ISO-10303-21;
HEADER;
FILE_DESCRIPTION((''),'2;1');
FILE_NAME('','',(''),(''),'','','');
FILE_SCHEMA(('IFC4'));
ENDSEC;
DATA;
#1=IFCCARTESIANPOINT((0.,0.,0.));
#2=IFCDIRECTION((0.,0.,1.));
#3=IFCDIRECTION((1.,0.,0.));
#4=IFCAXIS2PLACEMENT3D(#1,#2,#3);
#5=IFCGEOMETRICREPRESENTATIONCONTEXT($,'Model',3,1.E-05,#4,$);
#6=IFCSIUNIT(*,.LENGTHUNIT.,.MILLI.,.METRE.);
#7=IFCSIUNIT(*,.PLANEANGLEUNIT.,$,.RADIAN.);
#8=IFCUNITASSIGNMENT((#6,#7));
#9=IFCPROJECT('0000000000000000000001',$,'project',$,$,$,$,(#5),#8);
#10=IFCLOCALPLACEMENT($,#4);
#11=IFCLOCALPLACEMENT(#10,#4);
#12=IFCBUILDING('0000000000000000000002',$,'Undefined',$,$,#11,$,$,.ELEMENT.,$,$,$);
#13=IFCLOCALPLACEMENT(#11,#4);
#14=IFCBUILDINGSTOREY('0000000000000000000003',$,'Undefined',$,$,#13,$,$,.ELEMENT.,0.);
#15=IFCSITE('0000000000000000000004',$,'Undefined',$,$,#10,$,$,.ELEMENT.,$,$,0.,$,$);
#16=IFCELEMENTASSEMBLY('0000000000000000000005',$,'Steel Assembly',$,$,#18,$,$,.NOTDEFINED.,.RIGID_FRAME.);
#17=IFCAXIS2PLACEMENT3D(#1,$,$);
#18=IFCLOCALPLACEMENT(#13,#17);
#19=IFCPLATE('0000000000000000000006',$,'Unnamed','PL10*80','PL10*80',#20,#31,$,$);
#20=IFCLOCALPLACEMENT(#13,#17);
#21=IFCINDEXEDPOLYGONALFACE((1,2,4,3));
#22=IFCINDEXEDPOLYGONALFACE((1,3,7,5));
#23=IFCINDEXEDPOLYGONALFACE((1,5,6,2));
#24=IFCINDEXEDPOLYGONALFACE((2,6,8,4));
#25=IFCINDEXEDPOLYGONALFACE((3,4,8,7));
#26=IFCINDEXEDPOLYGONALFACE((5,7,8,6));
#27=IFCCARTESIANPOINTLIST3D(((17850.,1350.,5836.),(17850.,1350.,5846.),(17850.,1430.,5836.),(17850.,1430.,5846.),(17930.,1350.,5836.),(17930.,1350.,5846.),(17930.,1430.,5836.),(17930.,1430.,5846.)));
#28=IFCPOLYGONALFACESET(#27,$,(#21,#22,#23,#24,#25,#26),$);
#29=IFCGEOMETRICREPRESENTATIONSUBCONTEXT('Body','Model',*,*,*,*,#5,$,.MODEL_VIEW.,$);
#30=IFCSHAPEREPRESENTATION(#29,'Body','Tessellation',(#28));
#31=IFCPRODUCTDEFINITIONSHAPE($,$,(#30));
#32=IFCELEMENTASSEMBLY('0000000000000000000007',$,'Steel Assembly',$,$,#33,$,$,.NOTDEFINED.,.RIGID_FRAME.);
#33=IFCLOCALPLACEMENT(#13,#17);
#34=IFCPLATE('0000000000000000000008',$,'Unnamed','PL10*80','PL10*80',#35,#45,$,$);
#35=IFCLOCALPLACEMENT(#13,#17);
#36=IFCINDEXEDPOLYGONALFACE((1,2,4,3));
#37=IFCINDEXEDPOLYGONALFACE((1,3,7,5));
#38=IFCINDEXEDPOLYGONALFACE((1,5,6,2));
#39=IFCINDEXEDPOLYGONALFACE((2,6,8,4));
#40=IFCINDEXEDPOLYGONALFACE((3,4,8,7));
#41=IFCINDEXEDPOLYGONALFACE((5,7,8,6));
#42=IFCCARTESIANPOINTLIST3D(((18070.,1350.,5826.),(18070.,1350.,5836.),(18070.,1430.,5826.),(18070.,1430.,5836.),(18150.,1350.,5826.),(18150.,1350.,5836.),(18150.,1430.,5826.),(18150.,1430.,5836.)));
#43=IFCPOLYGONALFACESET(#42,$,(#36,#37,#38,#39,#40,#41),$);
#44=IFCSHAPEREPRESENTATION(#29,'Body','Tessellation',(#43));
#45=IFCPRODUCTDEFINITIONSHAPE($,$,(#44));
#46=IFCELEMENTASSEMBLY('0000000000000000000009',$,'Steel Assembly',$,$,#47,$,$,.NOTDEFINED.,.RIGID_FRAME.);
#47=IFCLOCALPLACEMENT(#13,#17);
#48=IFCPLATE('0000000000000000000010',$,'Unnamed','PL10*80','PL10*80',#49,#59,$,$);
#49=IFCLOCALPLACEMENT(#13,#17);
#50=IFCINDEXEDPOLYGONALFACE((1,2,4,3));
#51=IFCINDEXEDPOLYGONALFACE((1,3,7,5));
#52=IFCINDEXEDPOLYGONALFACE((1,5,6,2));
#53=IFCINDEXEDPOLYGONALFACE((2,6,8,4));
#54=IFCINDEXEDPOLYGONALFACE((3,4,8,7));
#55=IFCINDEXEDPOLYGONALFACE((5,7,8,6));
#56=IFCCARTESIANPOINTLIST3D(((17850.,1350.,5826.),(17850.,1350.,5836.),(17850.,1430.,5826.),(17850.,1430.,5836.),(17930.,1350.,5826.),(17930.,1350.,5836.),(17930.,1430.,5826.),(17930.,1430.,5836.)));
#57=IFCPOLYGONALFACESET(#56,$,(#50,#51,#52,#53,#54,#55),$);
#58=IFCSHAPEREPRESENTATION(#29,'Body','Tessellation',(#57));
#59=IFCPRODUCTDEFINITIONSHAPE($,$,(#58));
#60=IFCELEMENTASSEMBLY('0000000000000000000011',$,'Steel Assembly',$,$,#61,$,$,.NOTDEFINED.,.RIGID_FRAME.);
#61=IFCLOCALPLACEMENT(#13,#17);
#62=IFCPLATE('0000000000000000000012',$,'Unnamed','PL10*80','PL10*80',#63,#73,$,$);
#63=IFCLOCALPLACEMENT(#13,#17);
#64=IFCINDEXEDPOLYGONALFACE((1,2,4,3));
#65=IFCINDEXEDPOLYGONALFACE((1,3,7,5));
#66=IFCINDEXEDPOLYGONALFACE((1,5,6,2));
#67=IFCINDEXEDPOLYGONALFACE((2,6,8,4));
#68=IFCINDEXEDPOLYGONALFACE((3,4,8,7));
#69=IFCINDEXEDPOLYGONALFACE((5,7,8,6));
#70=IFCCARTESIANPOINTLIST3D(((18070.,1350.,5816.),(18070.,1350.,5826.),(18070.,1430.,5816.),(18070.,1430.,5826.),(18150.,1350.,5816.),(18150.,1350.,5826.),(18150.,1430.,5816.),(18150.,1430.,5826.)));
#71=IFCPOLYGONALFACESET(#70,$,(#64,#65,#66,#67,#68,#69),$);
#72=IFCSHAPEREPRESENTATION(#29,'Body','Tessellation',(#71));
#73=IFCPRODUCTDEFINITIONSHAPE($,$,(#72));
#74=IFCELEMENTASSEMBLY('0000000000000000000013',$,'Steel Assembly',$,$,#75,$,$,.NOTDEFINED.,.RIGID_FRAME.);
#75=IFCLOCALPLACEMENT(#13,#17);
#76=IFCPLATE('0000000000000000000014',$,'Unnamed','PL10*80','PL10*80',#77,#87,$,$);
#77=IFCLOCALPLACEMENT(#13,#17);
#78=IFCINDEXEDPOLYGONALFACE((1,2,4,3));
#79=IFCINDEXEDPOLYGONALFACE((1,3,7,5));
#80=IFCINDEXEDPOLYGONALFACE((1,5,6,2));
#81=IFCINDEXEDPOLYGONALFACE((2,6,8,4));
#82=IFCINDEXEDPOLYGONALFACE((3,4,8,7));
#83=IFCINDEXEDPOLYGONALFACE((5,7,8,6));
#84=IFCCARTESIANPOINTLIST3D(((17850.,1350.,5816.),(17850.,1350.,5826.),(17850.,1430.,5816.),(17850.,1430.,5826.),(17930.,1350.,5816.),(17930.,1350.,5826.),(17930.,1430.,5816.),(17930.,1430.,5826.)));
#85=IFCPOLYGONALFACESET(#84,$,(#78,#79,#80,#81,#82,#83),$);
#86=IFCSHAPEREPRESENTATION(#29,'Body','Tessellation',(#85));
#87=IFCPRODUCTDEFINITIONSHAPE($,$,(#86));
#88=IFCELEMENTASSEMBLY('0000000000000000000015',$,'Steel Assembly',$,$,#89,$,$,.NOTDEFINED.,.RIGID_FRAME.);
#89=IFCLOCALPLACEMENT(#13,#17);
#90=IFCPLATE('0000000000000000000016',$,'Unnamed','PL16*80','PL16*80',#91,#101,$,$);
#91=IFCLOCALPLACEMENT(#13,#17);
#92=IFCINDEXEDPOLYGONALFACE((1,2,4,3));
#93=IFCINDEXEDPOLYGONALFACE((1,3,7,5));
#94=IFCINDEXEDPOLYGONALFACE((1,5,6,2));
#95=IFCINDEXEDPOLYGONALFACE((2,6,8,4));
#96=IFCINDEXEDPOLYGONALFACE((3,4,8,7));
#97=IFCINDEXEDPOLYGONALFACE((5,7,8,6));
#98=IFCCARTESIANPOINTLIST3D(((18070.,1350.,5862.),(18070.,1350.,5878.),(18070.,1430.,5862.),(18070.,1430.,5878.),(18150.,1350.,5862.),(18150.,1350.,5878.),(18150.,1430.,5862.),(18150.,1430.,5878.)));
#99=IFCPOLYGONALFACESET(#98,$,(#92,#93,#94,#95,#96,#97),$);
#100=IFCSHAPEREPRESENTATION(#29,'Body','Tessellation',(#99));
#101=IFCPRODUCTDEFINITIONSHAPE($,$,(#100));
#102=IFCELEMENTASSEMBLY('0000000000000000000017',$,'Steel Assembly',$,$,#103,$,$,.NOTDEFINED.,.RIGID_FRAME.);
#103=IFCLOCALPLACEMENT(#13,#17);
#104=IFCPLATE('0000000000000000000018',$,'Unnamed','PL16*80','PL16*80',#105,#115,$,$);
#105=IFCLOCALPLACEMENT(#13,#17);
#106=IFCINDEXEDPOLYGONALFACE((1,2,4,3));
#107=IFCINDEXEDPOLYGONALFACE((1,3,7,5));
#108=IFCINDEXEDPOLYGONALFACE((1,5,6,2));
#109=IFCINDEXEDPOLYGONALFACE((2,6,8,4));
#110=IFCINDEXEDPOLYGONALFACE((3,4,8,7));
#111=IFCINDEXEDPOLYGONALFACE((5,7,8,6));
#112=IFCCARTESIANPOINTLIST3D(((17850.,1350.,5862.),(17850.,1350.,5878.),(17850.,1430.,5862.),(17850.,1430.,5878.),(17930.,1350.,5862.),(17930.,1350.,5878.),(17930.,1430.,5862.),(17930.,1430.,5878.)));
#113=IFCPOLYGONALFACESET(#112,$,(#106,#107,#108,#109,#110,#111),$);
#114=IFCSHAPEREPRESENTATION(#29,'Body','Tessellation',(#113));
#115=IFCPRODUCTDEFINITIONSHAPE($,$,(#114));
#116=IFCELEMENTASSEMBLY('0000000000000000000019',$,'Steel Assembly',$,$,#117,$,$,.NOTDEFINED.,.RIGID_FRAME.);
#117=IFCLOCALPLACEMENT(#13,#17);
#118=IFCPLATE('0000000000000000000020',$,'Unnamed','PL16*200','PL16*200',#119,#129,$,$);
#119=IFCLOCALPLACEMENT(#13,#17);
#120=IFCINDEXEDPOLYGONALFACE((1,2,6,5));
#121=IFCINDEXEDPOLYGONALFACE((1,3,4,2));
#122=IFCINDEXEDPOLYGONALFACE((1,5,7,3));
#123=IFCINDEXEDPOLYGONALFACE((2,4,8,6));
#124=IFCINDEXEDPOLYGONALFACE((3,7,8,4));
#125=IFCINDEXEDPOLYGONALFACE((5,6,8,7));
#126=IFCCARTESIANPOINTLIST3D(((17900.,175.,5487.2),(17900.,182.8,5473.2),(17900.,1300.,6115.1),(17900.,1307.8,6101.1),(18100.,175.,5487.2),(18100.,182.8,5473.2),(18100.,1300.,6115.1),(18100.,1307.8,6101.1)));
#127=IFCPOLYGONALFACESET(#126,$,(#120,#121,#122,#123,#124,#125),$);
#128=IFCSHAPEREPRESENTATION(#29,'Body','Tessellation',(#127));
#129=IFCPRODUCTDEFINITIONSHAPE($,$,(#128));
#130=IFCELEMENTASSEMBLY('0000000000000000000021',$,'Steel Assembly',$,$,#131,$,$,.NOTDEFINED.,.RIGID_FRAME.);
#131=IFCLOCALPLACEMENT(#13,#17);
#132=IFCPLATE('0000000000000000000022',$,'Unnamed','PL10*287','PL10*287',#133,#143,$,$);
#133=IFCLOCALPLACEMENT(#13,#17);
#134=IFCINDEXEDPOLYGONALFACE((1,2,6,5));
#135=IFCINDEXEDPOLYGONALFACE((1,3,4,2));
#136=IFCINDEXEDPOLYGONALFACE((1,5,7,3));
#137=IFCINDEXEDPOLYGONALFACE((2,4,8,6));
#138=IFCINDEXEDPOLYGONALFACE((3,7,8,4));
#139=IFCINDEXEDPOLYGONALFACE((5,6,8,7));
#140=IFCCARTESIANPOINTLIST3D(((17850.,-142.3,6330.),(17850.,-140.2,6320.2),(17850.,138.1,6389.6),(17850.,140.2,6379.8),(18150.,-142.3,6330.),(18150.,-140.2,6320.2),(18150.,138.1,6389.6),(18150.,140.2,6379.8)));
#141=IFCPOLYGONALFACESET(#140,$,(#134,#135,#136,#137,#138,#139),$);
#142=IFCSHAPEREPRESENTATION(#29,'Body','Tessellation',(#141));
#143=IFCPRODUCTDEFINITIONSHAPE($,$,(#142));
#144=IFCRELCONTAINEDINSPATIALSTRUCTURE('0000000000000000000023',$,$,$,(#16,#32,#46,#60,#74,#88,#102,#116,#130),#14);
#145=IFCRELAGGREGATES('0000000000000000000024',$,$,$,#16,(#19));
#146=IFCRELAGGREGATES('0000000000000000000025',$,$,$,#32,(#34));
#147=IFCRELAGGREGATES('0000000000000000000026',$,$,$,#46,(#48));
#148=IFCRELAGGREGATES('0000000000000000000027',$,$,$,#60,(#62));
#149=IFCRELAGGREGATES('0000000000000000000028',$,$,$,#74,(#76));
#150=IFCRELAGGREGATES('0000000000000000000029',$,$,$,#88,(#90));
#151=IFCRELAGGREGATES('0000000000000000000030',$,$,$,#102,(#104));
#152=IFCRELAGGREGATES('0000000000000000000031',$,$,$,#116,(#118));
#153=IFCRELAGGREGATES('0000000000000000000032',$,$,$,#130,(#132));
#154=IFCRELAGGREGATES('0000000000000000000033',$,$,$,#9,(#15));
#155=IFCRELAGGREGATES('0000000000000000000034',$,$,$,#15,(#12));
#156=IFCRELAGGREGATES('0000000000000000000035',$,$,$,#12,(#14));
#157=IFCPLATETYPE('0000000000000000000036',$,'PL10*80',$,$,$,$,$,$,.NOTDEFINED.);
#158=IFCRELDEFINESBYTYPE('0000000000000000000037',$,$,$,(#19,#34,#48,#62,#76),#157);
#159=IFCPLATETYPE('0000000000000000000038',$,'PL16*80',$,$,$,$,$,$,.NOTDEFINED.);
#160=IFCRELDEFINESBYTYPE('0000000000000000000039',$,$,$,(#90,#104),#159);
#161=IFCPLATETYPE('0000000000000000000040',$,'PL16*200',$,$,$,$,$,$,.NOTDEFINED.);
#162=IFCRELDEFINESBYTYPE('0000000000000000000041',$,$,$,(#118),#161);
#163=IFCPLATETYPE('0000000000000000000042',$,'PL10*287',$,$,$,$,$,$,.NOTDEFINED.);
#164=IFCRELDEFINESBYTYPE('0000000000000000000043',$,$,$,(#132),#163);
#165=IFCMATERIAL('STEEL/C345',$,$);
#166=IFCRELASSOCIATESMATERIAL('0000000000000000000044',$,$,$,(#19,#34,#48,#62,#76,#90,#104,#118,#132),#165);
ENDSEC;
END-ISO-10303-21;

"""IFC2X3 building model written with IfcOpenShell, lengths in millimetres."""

from ifc_helpers import new_model, si_unit, frame, origin_with_axes, place, context, subcontext, project, spatial, polyline, outline, extrude, material, type_object, element, aggregate, save


model = new_model("IFC2X3")

# Units and contexts
model_context = context("Model", 3, precision=1e-05, world=origin_with_axes())
body_context = subcontext(model_context, "Body", "Model", "MODEL_VIEW")
ifc_project = project(units=[si_unit("LENGTHUNIT", "METRE", prefix="MILLI"), si_unit("PLANEANGLEUNIT", "RADIAN")], contexts=[model_context])

# Site, building, storey
site_placement = place(None, origin_with_axes())
site = spatial("IfcSite", under=ifc_project, at=site_placement, Name="Undefined", CompositionType="ELEMENT", RefElevation=0.0)
building_placement = place(site_placement, origin_with_axes())
building = spatial("IfcBuilding", under=site, at=building_placement, Name="Undefined", CompositionType="ELEMENT")
storey_placement = place(building_placement, origin_with_axes())
storey = spatial("IfcBuildingStorey", under=building, at=storey_placement, Name="Undefined", CompositionType="ELEMENT", Elevation=0.0)

# Shared definitions
ifc_material = material(Name="STEEL/C345")

# Element assemblies, plates
plate_type_1 = type_object("IfcPlateType", Name="PL10*80", PredefinedType="NOTDEFINED")
assembly_1_placement = place(storey_placement, origin_with_axes())
assembly_1 = element("IfcElementAssembly", 1, at=assembly_1_placement, inside=storey, Name="Steel Assembly", AssemblyPlace="NOTDEFINED", PredefinedType="RIGID_FRAME")
plate_1_placement = place(assembly_1_placement, frame((17850.0, 1350.0, 5841.0), z_axis=(0.0, 0.0, -1.0), x_axis=(0.0, 1.0, 0.0)))
plate_1 = element("IfcPlate", 2, at=plate_1_placement, type_object=plate_type_1, material=ifc_material, Name="Unnamed", Description="PL10*80", ObjectType="PL10*80", context=body_context, shape_type="SweptSolid", body=[
    extrude(outline(polyline([(0.0, 0.0), (80.0, 0.0), (80.0, 80.0), (0.0, 80.0), (0.0, 0.0)])), frame((0.0, 0.0, -5.0), z_axis=(0.0, 0.0, 1.0), x_axis=(1.0, 0.0, 0.0)), (0.0, 0.0, 1.0), 10.0),
])
aggregate(assembly_1, [plate_1])
assembly_2_placement = place(storey_placement, origin_with_axes())
assembly_2 = element("IfcElementAssembly", 3, at=assembly_2_placement, inside=storey, Name="Steel Assembly", AssemblyPlace="NOTDEFINED", PredefinedType="RIGID_FRAME")
plate_2_placement = place(assembly_2_placement, frame((18150.0, 1350.0, 5831.0), z_axis=(0.0, 0.0, 1.0), x_axis=(0.0, 1.0, 0.0)))
plate_2 = element("IfcPlate", 4, at=plate_2_placement, type_object=plate_type_1, material=ifc_material, Name="Unnamed", Description="PL10*80", ObjectType="PL10*80", context=body_context, shape_type="SweptSolid", body=[
    extrude(outline(polyline([(0.0, 0.0), (80.0, 0.0), (80.0, 80.0), (0.0, 80.0), (0.0, 0.0)])), frame((0.0, 0.0, -5.0), z_axis=(0.0, 0.0, 1.0), x_axis=(1.0, 0.0, 0.0)), (0.0, 0.0, 1.0), 10.0),
])
aggregate(assembly_2, [plate_2])
assembly_3_placement = place(storey_placement, origin_with_axes())
assembly_3 = element("IfcElementAssembly", 5, at=assembly_3_placement, inside=storey, Name="Steel Assembly", AssemblyPlace="NOTDEFINED", PredefinedType="RIGID_FRAME")
plate_3_placement = place(assembly_3_placement, frame((17850.0, 1350.0, 5831.0), z_axis=(0.0, 0.0, -1.0), x_axis=(0.0, 1.0, 0.0)))
plate_3 = element("IfcPlate", 6, at=plate_3_placement, type_object=plate_type_1, material=ifc_material, Name="Unnamed", Description="PL10*80", ObjectType="PL10*80", context=body_context, shape_type="SweptSolid", body=[
    extrude(outline(polyline([(0.0, 0.0), (80.0, 0.0), (80.0, 80.0), (0.0, 80.0), (0.0, 0.0)])), frame((0.0, 0.0, -5.0), z_axis=(0.0, 0.0, 1.0), x_axis=(1.0, 0.0, 0.0)), (0.0, 0.0, 1.0), 10.0),
])
aggregate(assembly_3, [plate_3])
assembly_4_placement = place(storey_placement, origin_with_axes())
assembly_4 = element("IfcElementAssembly", 7, at=assembly_4_placement, inside=storey, Name="Steel Assembly", AssemblyPlace="NOTDEFINED", PredefinedType="RIGID_FRAME")
plate_4_placement = place(assembly_4_placement, frame((18150.0, 1350.0, 5821.0), z_axis=(0.0, 0.0, 1.0), x_axis=(0.0, 1.0, 0.0)))
plate_4 = element("IfcPlate", 8, at=plate_4_placement, type_object=plate_type_1, material=ifc_material, Name="Unnamed", Description="PL10*80", ObjectType="PL10*80", context=body_context, shape_type="SweptSolid", body=[
    extrude(outline(polyline([(0.0, 0.0), (80.0, 0.0), (80.0, 80.0), (0.0, 80.0), (0.0, 0.0)])), frame((0.0, 0.0, -5.0), z_axis=(0.0, 0.0, 1.0), x_axis=(1.0, 0.0, 0.0)), (0.0, 0.0, 1.0), 10.0),
])
aggregate(assembly_4, [plate_4])
assembly_5_placement = place(storey_placement, origin_with_axes())
assembly_5 = element("IfcElementAssembly", 9, at=assembly_5_placement, inside=storey, Name="Steel Assembly", AssemblyPlace="NOTDEFINED", PredefinedType="RIGID_FRAME")
plate_5_placement = place(assembly_5_placement, frame((17850.0, 1350.0, 5821.0), z_axis=(0.0, 0.0, -1.0), x_axis=(0.0, 1.0, 0.0)))
plate_5 = element("IfcPlate", 10, at=plate_5_placement, type_object=plate_type_1, material=ifc_material, Name="Unnamed", Description="PL10*80", ObjectType="PL10*80", context=body_context, shape_type="SweptSolid", body=[
    extrude(outline(polyline([(0.0, 0.0), (80.0, 0.0), (80.0, 80.0), (0.0, 80.0), (0.0, 0.0)])), frame((0.0, 0.0, -5.0), z_axis=(0.0, 0.0, 1.0), x_axis=(1.0, 0.0, 0.0)), (0.0, 0.0, 1.0), 10.0),
])
aggregate(assembly_5, [plate_5])
assembly_6_placement = place(storey_placement, origin_with_axes())
assembly_6 = element("IfcElementAssembly", 11, at=assembly_6_placement, inside=storey, Name="Steel Assembly", AssemblyPlace="NOTDEFINED", PredefinedType="RIGID_FRAME")
plate_type_2 = type_object("IfcPlateType", Name="PL16*80", PredefinedType="NOTDEFINED")
plate_6_placement = place(assembly_6_placement, frame((18150.0, 1350.0, 5870.0), z_axis=(0.0, 0.0, 1.0), x_axis=(0.0, 1.0, 0.0)))
plate_6 = element("IfcPlate", 12, at=plate_6_placement, type_object=plate_type_2, material=ifc_material, Name="Unnamed", Description="PL16*80", ObjectType="PL16*80", context=body_context, shape_type="SweptSolid", body=[
    extrude(outline(polyline([(0.0, 0.0), (80.0, 0.0), (80.0, 80.0), (0.0, 80.0), (0.0, 0.0)])), frame((0.0, 0.0, -8.0), z_axis=(0.0, 0.0, 1.0), x_axis=(1.0, 0.0, 0.0)), (0.0, 0.0, 1.0), 16.0),
])
aggregate(assembly_6, [plate_6])
assembly_7_placement = place(storey_placement, origin_with_axes())
assembly_7 = element("IfcElementAssembly", 13, at=assembly_7_placement, inside=storey, Name="Steel Assembly", AssemblyPlace="NOTDEFINED", PredefinedType="RIGID_FRAME")
plate_7_placement = place(assembly_7_placement, frame((17850.0, 1350.0, 5870.0), z_axis=(0.0, 0.0, -1.0), x_axis=(0.0, 1.0, 0.0)))
plate_7 = element("IfcPlate", 14, at=plate_7_placement, type_object=plate_type_2, material=ifc_material, Name="Unnamed", Description="PL16*80", ObjectType="PL16*80", context=body_context, shape_type="SweptSolid", body=[
    extrude(outline(polyline([(0.0, 0.0), (80.0, 0.0), (80.0, 80.0), (0.0, 80.0), (0.0, 0.0)])), frame((0.0, 0.0, -8.0), z_axis=(0.0, 0.0, 1.0), x_axis=(1.0, 0.0, 0.0)), (0.0, 0.0, 1.0), 16.0),
])
aggregate(assembly_7, [plate_7])
assembly_8_placement = place(storey_placement, origin_with_axes())
assembly_8 = element("IfcElementAssembly", 15, at=assembly_8_placement, inside=storey, Name="Steel Assembly", AssemblyPlace="NOTDEFINED", PredefinedType="RIGID_FRAME")
plate_type_3 = type_object("IfcPlateType", Name="PL16*200", PredefinedType="NOTDEFINED")
plate_8_placement = place(assembly_8_placement, frame((18100.0, 178.9, 5480.2), z_axis=(0.0, 0.487361, -0.8732), x_axis=(-1.0, 0.0, 0.0)))
plate_8 = element("IfcPlate", 16, at=plate_8_placement, type_object=plate_type_3, material=ifc_material, Name="Unnamed", Description="PL16*200", ObjectType="PL16*200", context=body_context, shape_type="SweptSolid", body=[
    extrude(outline(polyline([(0.0, 0.0), (200.0, 0.0), (200.0, 1288.4), (0.0, 1288.4), (0.0, 0.0)])), frame((0.0, 0.0, -8.0), z_axis=(0.0, 0.0, 1.0), x_axis=(1.0, 0.0, 0.0)), (0.0, 0.0, 1.0), 16.0),
])
aggregate(assembly_8, [plate_8])
assembly_9_placement = place(storey_placement, origin_with_axes())
assembly_9 = element("IfcElementAssembly", 17, at=assembly_9_placement, inside=storey, Name="Steel Assembly", AssemblyPlace="NOTDEFINED", PredefinedType="RIGID_FRAME")
plate_type_4 = type_object("IfcPlateType", Name="PL10*287", PredefinedType="NOTDEFINED")
plate_9_placement = place(assembly_9_placement, frame((18150.0, -141.3, 6325.1), z_axis=(0.0, 0.207859, -0.978159), x_axis=(-1.0, 0.0, 0.0)))
plate_9 = element("IfcPlate", 18, at=plate_9_placement, type_object=plate_type_4, material=ifc_material, Name="Unnamed", Description="PL10*287", ObjectType="PL10*287", context=body_context, shape_type="SweptSolid", body=[
    extrude(outline(polyline([(0.0, 0.0), (300.0, 0.0), (300.0, 286.7), (0.0, 286.7), (0.0, 0.0)])), frame((0.0, 0.0, -5.0), z_axis=(0.0, 0.0, 1.0), x_axis=(1.0, 0.0, 0.0)), (0.0, 0.0, 1.0), 10.0),
])
aggregate(assembly_9, [plate_9])

save(model, "model.ifc")
